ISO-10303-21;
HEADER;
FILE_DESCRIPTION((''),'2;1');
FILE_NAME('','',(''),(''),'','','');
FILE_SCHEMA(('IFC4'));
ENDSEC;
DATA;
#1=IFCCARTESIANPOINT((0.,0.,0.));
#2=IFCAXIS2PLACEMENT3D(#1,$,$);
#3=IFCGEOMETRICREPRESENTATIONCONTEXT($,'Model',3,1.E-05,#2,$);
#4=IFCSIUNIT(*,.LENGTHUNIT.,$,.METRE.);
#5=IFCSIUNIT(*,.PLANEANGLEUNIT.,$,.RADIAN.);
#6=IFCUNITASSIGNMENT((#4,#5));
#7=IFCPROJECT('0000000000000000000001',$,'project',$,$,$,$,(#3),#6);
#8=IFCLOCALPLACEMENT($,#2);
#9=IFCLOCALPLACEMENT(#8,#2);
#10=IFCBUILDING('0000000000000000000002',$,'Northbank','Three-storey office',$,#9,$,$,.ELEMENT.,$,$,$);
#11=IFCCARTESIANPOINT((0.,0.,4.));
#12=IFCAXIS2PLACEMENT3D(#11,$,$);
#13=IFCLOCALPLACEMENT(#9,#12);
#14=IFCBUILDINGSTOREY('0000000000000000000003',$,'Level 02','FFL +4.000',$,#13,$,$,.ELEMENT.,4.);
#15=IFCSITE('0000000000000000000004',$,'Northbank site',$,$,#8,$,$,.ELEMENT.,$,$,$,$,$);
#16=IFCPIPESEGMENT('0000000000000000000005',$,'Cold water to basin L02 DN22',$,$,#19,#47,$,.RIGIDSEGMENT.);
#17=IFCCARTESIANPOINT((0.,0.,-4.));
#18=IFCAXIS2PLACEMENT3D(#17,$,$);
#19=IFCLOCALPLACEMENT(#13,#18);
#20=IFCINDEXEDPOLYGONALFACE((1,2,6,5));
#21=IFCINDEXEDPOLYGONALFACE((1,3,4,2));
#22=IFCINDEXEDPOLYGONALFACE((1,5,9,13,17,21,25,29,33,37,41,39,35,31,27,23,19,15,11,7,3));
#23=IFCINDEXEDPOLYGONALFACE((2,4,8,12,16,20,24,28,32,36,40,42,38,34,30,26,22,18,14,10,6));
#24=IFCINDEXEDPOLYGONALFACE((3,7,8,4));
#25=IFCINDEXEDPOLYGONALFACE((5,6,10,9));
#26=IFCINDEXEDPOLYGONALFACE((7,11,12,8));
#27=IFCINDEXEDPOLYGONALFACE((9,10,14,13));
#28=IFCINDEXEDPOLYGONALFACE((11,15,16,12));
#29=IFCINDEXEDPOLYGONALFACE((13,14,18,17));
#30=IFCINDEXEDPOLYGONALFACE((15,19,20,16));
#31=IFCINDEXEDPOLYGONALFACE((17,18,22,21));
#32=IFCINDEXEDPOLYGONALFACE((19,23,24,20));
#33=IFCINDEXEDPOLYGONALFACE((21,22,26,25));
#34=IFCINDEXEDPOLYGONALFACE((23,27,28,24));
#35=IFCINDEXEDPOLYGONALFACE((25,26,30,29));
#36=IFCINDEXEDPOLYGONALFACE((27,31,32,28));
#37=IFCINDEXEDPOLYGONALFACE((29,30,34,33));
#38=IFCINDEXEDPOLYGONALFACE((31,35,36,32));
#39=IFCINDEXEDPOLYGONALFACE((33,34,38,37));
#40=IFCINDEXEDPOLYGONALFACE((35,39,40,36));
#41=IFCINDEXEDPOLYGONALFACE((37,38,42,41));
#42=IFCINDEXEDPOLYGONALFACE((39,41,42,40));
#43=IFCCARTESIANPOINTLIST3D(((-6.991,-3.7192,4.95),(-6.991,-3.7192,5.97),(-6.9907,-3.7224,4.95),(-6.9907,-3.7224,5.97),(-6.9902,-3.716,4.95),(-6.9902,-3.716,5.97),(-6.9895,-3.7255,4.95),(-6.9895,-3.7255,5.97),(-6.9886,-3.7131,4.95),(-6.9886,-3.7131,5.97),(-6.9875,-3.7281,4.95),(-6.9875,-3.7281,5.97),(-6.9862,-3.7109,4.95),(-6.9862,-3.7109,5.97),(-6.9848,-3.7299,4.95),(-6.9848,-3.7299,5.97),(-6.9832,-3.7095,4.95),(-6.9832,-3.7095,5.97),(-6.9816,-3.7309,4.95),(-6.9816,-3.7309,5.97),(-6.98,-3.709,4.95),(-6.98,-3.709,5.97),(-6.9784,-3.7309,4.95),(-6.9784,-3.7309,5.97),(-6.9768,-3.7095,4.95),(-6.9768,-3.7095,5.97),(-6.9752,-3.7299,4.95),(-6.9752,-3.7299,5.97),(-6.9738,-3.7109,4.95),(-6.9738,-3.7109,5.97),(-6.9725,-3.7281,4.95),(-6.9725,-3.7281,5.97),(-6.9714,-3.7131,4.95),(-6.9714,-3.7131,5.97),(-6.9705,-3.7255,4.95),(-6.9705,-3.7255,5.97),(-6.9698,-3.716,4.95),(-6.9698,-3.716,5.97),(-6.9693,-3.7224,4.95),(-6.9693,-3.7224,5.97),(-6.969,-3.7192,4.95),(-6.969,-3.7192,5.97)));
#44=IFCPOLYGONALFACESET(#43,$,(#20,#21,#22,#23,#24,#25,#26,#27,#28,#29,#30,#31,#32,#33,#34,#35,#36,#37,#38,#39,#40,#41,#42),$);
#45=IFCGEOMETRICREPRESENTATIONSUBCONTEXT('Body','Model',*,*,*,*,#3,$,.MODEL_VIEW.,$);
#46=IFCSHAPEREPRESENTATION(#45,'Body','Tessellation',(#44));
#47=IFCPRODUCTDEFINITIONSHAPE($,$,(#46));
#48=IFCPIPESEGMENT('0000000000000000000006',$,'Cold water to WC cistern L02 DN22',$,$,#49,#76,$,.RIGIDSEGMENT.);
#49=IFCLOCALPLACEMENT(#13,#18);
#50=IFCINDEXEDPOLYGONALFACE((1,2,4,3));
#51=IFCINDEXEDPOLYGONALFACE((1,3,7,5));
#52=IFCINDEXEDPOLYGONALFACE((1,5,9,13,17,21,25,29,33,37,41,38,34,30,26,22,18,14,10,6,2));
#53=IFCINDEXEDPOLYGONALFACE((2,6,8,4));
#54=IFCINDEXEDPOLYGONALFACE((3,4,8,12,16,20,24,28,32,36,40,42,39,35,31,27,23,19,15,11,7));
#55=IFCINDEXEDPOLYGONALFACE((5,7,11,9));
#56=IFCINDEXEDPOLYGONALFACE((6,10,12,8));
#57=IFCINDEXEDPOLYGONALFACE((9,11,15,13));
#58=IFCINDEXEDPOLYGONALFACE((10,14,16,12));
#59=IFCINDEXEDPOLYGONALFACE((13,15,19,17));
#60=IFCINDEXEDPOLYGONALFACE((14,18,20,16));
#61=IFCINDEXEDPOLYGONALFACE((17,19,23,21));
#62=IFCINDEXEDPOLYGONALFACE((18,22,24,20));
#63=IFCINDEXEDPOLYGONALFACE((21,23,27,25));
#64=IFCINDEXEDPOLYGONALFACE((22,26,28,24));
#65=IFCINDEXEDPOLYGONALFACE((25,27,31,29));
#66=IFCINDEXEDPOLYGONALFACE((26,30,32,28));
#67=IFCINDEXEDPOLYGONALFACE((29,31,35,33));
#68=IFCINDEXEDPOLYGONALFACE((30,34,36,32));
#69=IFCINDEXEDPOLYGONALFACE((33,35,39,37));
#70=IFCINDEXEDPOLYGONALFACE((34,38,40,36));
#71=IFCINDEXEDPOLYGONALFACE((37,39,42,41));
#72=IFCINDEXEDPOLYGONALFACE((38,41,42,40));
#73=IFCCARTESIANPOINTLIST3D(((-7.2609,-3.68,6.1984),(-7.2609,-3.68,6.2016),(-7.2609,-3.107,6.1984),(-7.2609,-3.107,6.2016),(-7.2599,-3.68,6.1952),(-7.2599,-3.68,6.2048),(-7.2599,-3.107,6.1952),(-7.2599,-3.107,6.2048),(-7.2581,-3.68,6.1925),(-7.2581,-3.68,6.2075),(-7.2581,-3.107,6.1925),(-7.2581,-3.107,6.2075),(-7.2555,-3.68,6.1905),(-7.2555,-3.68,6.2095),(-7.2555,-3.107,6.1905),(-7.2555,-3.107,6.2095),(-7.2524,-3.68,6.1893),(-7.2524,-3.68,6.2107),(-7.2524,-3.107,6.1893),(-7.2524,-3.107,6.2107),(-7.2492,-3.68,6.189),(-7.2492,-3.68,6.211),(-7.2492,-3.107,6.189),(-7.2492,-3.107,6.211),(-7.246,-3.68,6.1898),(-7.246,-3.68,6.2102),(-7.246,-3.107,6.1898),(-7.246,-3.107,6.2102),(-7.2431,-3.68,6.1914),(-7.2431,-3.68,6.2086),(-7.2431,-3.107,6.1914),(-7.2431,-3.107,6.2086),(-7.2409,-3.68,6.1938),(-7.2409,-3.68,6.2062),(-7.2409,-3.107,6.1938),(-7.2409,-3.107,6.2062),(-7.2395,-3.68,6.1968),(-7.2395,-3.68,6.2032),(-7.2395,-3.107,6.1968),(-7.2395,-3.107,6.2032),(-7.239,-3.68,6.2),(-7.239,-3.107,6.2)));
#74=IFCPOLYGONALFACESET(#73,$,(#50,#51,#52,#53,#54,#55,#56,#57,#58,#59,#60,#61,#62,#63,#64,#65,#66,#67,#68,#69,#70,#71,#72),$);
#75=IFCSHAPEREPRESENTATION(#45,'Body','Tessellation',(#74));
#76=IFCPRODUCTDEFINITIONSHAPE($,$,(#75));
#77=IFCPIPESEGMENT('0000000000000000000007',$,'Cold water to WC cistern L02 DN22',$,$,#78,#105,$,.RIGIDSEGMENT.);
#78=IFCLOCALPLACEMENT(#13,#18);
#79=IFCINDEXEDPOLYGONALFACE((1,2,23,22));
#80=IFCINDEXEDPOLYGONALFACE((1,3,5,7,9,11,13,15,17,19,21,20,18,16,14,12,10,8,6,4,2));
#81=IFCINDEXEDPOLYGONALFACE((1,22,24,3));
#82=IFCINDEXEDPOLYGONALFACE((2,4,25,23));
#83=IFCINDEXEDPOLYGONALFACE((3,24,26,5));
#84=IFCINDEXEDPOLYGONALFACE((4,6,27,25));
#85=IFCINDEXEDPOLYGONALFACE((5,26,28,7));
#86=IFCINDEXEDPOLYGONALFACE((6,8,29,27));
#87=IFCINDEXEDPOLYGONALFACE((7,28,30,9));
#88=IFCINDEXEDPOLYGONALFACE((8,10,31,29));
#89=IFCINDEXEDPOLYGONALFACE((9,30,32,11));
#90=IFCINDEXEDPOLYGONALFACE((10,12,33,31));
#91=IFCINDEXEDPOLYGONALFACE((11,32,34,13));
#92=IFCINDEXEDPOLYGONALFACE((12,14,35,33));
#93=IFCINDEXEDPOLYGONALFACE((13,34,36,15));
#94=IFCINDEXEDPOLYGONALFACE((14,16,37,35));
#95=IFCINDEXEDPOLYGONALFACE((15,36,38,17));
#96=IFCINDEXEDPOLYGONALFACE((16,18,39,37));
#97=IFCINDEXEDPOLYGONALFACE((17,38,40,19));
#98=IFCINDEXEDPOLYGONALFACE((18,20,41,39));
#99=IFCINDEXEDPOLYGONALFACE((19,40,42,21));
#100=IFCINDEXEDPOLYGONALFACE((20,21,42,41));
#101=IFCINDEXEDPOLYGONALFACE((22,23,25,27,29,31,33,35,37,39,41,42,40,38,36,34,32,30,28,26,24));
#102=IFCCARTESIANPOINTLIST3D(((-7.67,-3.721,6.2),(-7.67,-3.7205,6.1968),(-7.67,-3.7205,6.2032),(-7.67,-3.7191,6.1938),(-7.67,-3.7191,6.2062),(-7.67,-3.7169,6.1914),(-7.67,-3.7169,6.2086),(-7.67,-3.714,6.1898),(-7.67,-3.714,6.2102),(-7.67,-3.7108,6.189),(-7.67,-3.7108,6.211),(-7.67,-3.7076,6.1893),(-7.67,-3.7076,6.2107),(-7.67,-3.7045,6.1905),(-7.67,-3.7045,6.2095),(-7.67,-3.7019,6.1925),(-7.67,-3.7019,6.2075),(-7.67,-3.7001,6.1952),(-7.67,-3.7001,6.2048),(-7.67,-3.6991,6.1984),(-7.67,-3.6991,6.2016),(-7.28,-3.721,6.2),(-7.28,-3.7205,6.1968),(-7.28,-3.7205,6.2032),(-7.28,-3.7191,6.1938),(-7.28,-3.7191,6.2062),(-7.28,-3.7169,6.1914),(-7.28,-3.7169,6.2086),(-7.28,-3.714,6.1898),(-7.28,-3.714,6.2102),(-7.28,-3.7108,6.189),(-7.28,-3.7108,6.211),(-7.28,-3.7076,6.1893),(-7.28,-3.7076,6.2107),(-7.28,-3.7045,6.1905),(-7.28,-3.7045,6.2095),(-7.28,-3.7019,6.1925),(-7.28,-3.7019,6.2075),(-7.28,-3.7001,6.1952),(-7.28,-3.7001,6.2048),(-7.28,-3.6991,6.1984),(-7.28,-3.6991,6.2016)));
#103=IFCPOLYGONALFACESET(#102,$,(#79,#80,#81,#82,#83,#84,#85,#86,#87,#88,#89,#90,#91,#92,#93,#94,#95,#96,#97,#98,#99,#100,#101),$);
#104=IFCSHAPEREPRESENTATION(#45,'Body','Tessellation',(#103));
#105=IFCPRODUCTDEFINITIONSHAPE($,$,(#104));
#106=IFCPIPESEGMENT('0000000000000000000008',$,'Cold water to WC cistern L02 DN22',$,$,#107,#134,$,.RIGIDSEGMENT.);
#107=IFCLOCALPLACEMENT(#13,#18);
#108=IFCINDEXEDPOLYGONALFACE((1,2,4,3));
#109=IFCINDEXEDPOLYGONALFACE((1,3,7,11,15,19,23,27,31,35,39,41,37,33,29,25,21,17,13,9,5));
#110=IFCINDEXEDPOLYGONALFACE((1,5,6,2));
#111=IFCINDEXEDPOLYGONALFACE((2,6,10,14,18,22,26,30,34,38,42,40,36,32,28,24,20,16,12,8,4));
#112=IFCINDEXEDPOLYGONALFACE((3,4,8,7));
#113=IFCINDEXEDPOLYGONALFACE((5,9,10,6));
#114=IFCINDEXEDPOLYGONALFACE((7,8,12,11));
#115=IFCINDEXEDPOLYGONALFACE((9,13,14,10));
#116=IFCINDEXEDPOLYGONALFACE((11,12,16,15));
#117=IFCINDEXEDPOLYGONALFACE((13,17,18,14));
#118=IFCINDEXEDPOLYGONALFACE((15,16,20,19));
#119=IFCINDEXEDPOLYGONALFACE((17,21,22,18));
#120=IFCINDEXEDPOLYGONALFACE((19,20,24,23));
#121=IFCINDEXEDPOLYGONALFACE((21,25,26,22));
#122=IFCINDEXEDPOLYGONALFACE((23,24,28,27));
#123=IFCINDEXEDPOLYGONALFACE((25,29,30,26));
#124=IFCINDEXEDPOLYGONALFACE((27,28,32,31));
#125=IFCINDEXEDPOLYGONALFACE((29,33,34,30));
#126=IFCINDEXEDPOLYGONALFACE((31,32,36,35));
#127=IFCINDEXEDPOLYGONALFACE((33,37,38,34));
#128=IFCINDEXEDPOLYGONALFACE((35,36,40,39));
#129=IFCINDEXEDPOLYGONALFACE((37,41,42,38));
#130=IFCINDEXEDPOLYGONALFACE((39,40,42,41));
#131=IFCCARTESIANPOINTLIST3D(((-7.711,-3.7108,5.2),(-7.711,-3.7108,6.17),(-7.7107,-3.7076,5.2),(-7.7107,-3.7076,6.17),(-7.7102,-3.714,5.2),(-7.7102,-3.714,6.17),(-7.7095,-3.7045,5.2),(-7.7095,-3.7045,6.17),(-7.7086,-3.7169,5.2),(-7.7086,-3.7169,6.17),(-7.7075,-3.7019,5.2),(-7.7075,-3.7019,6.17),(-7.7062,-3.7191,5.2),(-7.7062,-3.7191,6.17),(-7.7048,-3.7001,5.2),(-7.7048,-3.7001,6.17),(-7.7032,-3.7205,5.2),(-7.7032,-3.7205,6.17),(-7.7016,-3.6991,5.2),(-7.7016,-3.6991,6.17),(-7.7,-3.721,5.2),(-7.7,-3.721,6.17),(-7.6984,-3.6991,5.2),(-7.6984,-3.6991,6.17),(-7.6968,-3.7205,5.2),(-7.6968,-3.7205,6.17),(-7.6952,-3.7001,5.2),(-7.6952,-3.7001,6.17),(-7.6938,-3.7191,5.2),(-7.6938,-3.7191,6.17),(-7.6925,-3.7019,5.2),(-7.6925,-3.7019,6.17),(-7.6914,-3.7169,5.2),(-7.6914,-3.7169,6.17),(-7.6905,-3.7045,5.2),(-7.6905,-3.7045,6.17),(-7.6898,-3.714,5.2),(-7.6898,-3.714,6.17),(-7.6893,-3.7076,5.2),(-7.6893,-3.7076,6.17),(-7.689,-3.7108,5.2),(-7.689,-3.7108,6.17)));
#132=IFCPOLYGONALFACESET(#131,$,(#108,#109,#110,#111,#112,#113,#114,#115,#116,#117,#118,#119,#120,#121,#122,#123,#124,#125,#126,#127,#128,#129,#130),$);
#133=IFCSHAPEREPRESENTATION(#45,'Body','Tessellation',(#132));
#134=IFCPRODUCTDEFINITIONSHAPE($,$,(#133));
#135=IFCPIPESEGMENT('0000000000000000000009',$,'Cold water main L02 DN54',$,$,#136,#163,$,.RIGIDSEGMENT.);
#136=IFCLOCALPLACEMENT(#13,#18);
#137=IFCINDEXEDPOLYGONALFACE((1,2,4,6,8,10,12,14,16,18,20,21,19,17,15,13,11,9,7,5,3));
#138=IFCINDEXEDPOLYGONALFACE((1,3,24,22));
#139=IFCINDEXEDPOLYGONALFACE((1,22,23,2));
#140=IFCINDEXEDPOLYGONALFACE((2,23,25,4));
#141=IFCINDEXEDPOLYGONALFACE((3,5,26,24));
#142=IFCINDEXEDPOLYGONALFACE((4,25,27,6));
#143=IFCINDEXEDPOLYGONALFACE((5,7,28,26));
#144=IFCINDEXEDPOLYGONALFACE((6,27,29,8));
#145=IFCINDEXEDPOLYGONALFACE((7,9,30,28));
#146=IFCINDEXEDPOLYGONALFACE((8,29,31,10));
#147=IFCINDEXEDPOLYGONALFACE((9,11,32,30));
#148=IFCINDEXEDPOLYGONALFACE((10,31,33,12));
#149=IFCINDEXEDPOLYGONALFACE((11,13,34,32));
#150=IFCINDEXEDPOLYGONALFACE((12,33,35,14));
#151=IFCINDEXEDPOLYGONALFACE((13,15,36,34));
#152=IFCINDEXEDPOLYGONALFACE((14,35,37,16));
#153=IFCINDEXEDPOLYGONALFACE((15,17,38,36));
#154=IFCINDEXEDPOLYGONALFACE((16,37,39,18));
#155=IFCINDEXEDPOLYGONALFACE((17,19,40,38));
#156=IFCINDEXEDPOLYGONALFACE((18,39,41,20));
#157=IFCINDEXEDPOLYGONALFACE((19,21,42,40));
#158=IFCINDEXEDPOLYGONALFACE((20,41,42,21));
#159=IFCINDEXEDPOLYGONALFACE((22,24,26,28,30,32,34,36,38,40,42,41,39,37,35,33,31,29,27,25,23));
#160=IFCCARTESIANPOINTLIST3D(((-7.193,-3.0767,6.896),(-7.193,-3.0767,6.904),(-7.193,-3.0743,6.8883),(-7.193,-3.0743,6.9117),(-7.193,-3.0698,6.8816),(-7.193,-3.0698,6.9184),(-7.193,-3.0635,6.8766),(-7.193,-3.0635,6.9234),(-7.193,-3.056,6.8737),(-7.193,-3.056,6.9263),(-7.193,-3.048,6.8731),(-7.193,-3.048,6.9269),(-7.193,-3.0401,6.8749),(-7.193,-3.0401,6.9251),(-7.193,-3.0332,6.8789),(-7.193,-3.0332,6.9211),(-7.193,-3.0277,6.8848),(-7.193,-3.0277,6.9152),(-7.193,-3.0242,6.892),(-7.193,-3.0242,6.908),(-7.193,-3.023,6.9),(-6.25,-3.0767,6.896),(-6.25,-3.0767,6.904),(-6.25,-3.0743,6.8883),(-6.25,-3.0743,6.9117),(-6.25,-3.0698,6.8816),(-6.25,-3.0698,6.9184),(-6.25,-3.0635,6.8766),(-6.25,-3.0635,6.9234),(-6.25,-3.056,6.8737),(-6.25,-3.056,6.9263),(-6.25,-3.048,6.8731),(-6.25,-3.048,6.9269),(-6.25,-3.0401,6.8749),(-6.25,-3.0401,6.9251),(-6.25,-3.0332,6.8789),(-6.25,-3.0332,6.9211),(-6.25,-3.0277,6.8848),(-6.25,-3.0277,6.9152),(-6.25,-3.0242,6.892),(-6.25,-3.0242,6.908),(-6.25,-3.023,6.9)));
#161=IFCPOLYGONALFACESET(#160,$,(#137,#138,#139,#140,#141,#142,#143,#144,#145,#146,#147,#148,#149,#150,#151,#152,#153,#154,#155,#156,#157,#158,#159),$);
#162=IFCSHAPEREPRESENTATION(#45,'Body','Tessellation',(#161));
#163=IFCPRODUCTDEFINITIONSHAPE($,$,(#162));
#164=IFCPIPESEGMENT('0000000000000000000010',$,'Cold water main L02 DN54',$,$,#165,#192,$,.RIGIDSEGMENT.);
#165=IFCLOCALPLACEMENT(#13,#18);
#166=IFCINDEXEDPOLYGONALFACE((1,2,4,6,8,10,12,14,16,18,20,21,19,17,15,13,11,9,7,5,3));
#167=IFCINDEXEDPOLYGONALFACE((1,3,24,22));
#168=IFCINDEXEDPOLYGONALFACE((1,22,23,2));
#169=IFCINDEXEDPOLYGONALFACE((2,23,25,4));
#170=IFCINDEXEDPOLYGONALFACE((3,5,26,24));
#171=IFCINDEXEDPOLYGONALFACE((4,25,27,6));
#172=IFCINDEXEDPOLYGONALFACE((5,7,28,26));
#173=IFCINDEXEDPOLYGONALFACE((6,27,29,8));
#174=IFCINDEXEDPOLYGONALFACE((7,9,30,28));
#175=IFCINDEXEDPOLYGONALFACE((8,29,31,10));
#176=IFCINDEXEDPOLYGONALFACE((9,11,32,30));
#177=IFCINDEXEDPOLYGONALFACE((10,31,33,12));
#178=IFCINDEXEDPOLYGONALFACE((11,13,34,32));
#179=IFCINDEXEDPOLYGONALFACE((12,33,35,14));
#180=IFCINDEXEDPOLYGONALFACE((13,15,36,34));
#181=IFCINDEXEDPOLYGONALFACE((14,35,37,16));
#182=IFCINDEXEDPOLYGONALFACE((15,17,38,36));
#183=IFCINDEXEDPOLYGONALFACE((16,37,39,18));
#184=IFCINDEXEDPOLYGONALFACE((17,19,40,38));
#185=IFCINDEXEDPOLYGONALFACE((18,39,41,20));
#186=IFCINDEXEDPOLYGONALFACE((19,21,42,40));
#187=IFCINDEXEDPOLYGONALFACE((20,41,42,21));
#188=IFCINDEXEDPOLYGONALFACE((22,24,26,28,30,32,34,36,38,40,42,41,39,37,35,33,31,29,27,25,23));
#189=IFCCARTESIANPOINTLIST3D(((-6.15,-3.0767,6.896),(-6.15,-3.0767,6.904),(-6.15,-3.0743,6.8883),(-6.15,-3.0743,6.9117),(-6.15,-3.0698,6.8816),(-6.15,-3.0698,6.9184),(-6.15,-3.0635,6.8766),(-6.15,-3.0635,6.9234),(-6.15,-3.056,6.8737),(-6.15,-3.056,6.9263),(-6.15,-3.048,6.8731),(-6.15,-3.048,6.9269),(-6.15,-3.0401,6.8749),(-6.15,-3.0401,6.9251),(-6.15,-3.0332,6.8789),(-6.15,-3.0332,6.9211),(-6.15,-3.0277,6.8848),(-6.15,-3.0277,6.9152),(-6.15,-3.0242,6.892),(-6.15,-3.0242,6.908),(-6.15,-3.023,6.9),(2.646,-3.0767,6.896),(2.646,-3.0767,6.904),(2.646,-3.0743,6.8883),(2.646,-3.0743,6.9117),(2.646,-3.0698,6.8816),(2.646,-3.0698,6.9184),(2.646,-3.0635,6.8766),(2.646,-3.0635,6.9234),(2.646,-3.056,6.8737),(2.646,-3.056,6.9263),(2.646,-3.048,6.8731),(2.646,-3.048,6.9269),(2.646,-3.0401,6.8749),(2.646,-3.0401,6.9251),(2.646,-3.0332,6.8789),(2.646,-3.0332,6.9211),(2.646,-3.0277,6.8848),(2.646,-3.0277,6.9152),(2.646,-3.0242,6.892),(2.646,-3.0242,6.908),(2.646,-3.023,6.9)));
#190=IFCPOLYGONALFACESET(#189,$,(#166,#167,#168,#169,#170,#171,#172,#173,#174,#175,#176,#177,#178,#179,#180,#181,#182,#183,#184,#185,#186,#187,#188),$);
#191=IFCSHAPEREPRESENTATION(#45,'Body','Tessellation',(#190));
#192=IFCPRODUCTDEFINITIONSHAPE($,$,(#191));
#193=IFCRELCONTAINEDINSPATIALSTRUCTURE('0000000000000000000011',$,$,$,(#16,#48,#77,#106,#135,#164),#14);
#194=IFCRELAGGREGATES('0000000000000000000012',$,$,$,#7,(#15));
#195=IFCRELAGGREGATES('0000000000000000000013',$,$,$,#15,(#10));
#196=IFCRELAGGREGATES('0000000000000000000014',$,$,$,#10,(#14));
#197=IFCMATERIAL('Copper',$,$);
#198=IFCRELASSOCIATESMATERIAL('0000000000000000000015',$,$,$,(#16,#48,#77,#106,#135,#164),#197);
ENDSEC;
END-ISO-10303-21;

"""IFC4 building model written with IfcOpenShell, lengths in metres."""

from ifc_helpers import new_model, si_unit, frame, origin, place, context, subcontext, project, spatial, circle, extrude, material, element, save


model = new_model("IFC4")

# Units and contexts
model_context = context("Model", 3, precision=1e-05, world=origin())
body_context = subcontext(model_context, "Body", "Model", "MODEL_VIEW")
ifc_project = project(units=[si_unit("LENGTHUNIT", "METRE"), si_unit("PLANEANGLEUNIT", "RADIAN")], contexts=[model_context])

# Site, building, storey
site_placement = place(None, origin())
site = spatial("IfcSite", under=ifc_project, at=site_placement, Name="Northbank site", CompositionType="ELEMENT")
building_placement = place(site_placement, origin())
building = spatial("IfcBuilding", under=site, at=building_placement, Name="Northbank", Description="Three-storey office", CompositionType="ELEMENT")
storey_placement = place(building_placement, frame((0.0, 0.0, 4.0)))
storey = spatial("IfcBuildingStorey", under=building, at=storey_placement, Name="Level 02", Description="FFL +4.000", CompositionType="ELEMENT", Elevation=4.0)

# Shared definitions
ifc_material = material(Name="Copper")

# Pipe segments
pipe_segment_1_placement = place(storey_placement, frame((0.0, 0.0, -4.0)))
element("IfcPipeSegment", 1, at=pipe_segment_1_placement, inside=storey, material=ifc_material, Name="Cold water to basin L02 DN22", PredefinedType="RIGIDSEGMENT", context=body_context, shape_type="SweptSolid", body=[
    extrude(circle(Radius=0.011), frame((-6.98, -3.72, 5.97), z_axis=(0.0, 0.0, -1.0), x_axis=(0.0, 1.0, 0.0)), (0.0, 0.0, 1.0), 1.02),
])
pipe_segment_2_placement = place(storey_placement, frame((0.0, 0.0, -4.0)))
element("IfcPipeSegment", 2, at=pipe_segment_2_placement, inside=storey, material=ifc_material, Name="Cold water to WC cistern L02 DN22", PredefinedType="RIGIDSEGMENT", context=body_context, shape_type="SweptSolid", body=[
    extrude(circle(Radius=0.011), frame((-7.25, -3.107, 6.2), z_axis=(0.0, -1.0, 0.0), x_axis=(1.0, 0.0, 0.0)), (0.0, 0.0, 1.0), 0.573),
])
pipe_segment_3_placement = place(storey_placement, frame((0.0, 0.0, -4.0)))
element("IfcPipeSegment", 3, at=pipe_segment_3_placement, inside=storey, material=ifc_material, Name="Cold water to WC cistern L02 DN22", PredefinedType="RIGIDSEGMENT", context=body_context, shape_type="SweptSolid", body=[
    extrude(circle(Radius=0.011), frame((-7.28, -3.71, 6.2), z_axis=(-1.0, 0.0, 0.0), x_axis=(0.0, -1.0, 0.0)), (0.0, 0.0, 1.0), 0.39),
])
pipe_segment_4_placement = place(storey_placement, frame((0.0, 0.0, -4.0)))
element("IfcPipeSegment", 4, at=pipe_segment_4_placement, inside=storey, material=ifc_material, Name="Cold water to WC cistern L02 DN22", PredefinedType="RIGIDSEGMENT", context=body_context, shape_type="SweptSolid", body=[
    extrude(circle(Radius=0.011), frame((-7.7, -3.71, 6.17), z_axis=(0.0, 0.0, -1.0), x_axis=(0.0, -1.0, 0.0)), (0.0, 0.0, 1.0), 0.97),
])
pipe_segment_5_placement = place(storey_placement, frame((0.0, 0.0, -4.0)))
element("IfcPipeSegment", 5, at=pipe_segment_5_placement, inside=storey, material=ifc_material, Name="Cold water main L02 DN54", PredefinedType="RIGIDSEGMENT", context=body_context, shape_type="SweptSolid", body=[
    extrude(circle(Radius=0.027), frame((-7.193, -3.05, 6.9), z_axis=(1.0, 0.0, 0.0), x_axis=(0.0, 1.0, 0.0)), (0.0, 0.0, 1.0), 0.943),
])

# Pipe segment
pipe_segment_6_placement = place(storey_placement, frame((0.0, 0.0, -4.0)))
element("IfcPipeSegment", 6, at=pipe_segment_6_placement, inside=storey, material=ifc_material, Name="Cold water main L02 DN54", PredefinedType="RIGIDSEGMENT", context=body_context, shape_type="SweptSolid", body=[
    extrude(circle(Radius=0.027), frame((-6.15, -3.05, 6.9), z_axis=(1.0, 0.0, 0.0), x_axis=(0.0, 1.0, 0.0)), (0.0, 0.0, 1.0), 8.796),
])

save(model, "model.ifc")
